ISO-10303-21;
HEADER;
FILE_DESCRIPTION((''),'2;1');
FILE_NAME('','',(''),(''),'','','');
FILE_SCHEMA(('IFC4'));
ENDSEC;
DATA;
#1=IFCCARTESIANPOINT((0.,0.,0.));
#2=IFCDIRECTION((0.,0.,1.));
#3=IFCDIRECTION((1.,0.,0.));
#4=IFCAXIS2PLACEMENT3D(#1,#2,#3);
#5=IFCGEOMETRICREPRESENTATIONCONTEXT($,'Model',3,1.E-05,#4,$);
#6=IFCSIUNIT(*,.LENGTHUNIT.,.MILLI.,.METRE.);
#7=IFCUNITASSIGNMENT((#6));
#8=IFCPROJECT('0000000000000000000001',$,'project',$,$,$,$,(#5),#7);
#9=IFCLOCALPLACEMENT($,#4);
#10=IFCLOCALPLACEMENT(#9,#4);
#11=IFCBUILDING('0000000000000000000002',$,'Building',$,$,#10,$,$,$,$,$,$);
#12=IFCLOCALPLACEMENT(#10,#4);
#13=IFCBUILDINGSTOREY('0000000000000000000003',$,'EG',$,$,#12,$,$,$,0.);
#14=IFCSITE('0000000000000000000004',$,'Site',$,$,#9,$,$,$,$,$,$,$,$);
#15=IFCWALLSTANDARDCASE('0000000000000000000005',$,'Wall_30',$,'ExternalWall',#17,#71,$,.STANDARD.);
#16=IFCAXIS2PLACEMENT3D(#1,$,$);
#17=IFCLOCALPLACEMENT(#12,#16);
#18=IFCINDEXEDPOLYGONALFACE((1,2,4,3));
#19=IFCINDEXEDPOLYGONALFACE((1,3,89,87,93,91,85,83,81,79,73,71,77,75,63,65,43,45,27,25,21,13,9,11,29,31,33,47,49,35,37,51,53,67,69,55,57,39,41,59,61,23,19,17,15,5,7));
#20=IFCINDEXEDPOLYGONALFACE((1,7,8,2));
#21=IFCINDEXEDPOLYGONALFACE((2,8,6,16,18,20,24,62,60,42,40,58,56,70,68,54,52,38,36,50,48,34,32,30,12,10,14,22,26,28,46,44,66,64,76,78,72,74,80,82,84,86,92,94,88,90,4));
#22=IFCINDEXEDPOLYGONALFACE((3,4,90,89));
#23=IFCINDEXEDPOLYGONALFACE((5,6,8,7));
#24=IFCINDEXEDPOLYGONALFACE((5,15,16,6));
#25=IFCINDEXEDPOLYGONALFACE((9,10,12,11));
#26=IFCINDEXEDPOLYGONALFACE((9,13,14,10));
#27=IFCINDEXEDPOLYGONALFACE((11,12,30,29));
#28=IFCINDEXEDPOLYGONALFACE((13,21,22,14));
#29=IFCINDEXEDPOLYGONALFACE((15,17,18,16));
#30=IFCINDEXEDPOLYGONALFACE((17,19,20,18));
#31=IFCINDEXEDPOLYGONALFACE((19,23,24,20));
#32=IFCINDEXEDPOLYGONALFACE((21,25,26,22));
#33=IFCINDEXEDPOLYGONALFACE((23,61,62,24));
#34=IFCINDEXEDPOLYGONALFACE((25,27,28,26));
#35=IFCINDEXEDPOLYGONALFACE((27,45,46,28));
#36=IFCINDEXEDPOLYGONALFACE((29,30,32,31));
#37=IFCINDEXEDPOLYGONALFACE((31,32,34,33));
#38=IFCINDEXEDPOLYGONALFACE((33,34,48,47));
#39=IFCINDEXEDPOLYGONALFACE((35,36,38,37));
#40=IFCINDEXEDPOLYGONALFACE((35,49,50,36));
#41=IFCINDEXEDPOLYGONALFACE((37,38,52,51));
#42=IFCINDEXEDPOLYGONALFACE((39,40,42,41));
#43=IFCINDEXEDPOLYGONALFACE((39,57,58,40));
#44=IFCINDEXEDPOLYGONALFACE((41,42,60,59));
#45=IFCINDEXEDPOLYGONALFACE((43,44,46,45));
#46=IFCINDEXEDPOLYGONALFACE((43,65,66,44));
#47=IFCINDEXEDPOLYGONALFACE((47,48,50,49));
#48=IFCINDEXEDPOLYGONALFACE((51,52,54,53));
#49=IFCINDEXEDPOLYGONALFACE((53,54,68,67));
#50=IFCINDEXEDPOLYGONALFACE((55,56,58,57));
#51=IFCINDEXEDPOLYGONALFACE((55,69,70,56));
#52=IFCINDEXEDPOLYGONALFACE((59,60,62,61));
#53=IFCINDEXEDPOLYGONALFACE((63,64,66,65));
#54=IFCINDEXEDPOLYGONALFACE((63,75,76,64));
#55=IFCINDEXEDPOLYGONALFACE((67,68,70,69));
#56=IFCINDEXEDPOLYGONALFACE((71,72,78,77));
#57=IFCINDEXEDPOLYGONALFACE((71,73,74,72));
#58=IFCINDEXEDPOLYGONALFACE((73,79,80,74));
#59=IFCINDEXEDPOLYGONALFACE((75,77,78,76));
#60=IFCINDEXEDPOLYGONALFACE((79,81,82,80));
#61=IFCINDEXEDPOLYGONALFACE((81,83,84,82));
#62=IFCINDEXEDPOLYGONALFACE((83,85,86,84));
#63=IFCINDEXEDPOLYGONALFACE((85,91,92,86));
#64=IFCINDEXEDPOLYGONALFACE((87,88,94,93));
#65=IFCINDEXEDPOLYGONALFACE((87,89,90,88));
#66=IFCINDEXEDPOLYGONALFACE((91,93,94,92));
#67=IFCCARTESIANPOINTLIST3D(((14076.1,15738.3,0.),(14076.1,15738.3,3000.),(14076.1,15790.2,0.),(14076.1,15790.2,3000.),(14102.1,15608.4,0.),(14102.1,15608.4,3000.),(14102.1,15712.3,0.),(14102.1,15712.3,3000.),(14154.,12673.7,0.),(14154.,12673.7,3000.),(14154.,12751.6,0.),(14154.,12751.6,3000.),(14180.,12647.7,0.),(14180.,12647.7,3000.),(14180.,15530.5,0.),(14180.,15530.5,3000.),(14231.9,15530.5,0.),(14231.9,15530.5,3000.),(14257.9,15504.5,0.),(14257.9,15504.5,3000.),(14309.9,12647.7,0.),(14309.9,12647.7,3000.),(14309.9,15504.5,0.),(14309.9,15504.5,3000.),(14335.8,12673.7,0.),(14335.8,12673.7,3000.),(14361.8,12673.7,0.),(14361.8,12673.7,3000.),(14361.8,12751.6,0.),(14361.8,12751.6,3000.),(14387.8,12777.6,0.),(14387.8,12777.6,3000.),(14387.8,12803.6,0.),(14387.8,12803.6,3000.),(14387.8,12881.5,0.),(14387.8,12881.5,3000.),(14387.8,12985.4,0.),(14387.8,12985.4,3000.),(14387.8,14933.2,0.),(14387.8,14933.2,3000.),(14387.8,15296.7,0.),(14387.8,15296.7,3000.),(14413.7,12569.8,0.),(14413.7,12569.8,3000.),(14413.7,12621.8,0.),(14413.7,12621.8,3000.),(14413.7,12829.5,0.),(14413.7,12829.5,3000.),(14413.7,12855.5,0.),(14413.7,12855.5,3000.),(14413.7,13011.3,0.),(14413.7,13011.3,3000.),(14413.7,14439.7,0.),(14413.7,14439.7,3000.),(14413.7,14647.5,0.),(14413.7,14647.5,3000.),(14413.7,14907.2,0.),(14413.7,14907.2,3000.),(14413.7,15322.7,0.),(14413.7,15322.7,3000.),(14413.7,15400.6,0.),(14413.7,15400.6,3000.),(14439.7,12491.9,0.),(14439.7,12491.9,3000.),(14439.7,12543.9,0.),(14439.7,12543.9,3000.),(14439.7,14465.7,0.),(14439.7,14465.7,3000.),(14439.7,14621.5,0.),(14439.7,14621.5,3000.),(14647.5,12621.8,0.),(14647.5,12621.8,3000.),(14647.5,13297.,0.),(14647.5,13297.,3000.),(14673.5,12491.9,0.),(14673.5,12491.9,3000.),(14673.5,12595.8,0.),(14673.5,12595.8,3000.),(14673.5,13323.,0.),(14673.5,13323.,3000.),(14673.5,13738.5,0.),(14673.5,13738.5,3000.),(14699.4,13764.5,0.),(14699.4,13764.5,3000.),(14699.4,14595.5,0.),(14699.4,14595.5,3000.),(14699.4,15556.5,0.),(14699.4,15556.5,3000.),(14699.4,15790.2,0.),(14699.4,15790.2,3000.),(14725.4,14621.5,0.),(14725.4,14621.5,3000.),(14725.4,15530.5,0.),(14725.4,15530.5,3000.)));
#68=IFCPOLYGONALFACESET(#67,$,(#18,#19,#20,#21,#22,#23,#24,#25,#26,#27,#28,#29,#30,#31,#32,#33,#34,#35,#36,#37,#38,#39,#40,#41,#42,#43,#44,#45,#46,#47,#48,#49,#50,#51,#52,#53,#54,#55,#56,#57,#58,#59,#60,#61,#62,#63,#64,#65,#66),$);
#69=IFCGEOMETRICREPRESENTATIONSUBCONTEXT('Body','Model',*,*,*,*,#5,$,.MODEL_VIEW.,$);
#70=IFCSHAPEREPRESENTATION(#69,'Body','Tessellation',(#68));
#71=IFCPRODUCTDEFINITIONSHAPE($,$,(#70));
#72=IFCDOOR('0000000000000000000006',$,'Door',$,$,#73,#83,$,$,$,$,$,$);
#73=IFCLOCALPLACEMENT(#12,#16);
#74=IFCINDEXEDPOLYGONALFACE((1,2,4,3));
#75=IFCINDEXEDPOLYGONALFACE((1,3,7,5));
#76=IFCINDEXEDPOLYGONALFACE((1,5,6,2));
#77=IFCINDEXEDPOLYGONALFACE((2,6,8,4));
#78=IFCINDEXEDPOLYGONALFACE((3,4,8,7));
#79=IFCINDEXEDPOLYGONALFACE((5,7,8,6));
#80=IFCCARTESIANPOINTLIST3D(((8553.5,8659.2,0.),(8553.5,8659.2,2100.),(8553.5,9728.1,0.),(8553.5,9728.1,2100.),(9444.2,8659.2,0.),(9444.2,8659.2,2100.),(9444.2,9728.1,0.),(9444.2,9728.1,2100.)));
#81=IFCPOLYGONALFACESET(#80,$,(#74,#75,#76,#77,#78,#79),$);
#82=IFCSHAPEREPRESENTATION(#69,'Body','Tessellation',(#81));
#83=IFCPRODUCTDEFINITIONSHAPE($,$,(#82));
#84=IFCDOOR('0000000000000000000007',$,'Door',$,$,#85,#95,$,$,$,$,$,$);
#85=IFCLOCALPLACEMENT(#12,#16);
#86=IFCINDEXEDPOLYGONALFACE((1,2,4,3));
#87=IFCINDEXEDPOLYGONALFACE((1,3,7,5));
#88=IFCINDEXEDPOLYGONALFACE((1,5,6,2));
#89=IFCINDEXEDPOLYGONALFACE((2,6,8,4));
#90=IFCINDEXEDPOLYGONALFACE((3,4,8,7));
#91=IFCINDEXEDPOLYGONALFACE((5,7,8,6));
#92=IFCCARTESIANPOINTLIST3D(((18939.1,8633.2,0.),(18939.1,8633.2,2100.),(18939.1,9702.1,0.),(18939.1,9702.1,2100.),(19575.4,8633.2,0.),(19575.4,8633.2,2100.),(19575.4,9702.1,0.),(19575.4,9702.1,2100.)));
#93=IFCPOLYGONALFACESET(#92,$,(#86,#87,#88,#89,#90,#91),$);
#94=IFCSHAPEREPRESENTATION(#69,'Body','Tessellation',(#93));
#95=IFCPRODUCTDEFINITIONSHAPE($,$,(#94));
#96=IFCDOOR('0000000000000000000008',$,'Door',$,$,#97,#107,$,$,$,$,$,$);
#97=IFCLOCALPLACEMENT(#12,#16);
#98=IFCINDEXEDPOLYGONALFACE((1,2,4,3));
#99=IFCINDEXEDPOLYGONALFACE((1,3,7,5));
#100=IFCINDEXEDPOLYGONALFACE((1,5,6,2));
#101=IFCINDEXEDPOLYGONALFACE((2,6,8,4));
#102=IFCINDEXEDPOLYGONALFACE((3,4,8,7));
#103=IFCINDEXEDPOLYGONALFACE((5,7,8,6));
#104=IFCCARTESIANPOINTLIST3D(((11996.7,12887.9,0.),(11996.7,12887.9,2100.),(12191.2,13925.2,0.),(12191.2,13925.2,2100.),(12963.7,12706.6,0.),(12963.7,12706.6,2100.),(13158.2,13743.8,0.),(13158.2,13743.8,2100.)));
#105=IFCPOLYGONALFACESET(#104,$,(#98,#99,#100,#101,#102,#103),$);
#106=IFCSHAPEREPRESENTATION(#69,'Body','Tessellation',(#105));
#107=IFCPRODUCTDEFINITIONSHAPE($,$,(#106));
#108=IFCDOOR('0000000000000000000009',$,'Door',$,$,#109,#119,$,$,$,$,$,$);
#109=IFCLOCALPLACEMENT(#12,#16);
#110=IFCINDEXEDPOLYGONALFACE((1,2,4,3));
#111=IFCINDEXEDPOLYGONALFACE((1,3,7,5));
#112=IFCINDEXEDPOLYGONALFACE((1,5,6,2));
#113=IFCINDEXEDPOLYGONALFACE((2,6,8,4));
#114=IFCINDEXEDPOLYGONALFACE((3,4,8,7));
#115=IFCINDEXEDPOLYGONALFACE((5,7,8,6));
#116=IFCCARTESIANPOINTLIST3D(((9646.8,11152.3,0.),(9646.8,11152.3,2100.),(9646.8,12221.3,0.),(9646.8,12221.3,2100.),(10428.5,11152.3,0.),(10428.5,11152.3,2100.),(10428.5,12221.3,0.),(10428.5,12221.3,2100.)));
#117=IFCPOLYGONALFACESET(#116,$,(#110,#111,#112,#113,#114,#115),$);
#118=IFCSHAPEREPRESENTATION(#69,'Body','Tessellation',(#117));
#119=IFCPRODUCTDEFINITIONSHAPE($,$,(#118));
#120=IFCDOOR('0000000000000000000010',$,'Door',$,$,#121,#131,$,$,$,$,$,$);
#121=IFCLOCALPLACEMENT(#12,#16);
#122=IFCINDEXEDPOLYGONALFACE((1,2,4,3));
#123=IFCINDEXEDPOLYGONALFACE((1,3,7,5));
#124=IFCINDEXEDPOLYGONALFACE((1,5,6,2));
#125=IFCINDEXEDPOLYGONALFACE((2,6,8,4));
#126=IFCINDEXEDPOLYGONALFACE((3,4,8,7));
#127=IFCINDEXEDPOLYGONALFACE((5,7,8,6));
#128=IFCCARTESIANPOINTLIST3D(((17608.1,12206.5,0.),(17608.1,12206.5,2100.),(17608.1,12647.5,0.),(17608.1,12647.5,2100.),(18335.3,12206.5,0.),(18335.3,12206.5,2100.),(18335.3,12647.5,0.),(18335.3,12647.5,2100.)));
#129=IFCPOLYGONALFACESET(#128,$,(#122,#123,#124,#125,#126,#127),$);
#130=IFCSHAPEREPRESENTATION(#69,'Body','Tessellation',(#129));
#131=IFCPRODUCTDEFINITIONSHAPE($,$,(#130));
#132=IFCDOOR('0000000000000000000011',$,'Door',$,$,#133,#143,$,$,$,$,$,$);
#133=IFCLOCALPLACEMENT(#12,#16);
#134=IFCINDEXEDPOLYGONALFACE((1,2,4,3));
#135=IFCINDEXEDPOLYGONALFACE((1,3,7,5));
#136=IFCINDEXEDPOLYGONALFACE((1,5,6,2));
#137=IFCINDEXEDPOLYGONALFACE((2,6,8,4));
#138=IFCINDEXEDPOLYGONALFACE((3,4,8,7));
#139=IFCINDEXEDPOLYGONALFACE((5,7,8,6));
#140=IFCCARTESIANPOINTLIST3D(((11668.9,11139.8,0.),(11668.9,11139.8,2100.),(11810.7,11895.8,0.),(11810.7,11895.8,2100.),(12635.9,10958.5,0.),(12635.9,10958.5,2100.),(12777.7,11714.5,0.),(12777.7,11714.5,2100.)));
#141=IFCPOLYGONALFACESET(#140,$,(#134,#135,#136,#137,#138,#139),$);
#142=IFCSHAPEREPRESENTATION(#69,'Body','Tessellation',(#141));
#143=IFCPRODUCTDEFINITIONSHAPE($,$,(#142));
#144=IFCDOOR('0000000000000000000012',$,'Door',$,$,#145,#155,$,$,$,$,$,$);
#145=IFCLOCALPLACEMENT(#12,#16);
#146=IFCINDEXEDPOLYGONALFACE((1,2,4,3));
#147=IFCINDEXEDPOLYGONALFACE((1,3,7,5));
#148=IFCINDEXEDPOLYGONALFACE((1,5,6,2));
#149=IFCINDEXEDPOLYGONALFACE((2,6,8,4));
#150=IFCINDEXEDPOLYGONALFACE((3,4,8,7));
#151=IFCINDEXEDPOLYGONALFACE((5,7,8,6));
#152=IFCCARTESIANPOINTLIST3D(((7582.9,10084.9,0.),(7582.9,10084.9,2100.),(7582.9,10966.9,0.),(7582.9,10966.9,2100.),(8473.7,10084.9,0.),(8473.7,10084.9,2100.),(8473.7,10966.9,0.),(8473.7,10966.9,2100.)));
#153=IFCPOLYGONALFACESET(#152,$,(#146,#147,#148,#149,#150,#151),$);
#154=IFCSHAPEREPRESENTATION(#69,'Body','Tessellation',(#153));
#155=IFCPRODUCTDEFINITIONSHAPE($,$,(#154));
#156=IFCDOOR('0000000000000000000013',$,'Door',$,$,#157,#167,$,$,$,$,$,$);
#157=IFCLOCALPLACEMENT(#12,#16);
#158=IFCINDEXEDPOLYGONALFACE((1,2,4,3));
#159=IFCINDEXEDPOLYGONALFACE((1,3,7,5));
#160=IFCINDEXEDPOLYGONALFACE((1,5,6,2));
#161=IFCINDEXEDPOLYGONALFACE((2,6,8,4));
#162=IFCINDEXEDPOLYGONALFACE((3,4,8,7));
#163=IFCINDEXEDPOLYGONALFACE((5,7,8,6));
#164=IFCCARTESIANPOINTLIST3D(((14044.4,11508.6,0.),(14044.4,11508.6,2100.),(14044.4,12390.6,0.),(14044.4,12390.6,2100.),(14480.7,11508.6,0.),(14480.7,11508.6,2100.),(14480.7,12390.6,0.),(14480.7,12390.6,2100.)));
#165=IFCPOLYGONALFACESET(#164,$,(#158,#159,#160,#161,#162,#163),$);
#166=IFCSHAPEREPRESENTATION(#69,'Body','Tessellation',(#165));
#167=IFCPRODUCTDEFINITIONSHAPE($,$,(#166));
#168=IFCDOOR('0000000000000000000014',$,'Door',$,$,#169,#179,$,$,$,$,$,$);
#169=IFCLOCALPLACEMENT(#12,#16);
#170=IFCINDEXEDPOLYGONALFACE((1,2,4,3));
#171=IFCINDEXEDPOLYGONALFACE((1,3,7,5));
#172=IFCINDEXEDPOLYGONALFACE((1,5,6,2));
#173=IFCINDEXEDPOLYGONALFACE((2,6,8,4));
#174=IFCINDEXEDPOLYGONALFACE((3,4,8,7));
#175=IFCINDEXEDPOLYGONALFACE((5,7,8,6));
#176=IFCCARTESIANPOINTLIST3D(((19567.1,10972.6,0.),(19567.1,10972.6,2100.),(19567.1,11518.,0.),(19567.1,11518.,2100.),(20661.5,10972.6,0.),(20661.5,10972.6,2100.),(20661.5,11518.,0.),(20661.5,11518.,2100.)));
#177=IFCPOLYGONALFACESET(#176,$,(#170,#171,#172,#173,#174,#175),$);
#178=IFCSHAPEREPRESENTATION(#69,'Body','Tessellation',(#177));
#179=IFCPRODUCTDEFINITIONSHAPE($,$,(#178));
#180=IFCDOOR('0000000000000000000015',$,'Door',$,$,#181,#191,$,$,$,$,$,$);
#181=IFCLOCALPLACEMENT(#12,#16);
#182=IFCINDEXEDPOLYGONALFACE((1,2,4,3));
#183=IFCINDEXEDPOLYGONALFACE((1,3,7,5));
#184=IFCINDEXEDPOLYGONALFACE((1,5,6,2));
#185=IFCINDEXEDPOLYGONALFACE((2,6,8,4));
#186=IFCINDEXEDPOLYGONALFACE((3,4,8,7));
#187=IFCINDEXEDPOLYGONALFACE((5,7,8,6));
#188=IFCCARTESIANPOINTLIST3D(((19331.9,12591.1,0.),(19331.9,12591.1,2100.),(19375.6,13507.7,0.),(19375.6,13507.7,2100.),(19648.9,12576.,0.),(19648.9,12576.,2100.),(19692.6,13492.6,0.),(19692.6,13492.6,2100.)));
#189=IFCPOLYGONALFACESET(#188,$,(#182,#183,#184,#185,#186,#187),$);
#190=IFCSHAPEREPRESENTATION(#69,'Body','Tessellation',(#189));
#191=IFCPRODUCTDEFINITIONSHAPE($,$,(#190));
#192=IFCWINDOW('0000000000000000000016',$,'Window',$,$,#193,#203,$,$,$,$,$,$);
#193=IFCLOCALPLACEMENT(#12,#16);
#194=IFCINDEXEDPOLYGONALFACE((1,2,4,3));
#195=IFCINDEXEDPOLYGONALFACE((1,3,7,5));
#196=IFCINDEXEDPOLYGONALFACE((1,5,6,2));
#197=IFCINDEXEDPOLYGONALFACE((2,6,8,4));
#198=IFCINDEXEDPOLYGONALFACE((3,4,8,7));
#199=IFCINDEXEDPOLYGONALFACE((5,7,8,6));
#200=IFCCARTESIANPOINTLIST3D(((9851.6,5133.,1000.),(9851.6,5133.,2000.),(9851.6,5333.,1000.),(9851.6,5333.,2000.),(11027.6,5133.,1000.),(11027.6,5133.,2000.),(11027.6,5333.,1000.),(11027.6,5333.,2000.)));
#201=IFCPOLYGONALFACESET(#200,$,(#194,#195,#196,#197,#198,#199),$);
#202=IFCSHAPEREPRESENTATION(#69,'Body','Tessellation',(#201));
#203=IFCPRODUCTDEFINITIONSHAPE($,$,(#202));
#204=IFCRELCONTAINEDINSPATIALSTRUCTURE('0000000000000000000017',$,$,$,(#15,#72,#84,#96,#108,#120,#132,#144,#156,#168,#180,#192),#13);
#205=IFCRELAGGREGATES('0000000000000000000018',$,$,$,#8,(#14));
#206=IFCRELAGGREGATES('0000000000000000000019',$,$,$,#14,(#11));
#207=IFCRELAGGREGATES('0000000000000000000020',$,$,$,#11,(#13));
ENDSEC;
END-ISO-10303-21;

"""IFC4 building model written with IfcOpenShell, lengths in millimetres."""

from ifc_helpers import new_model, si_unit, frame, origin_with_axes, place, context, subcontext, project, spatial, polyline, rectangle, outline, extrude, element, save


model = new_model("IFC4")

# Units and contexts
model_context = context("Model", 3, precision=1e-05, world=origin_with_axes())
body_context = subcontext(model_context, "Body", "Model", "MODEL_VIEW")
ifc_project = project(units=[si_unit("LENGTHUNIT", "METRE", prefix="MILLI")], contexts=[model_context])

# Site, building, storey
site_placement = place(None, origin_with_axes())
site = spatial("IfcSite", under=ifc_project, at=site_placement, Name="Site")
building_placement = place(site_placement, origin_with_axes())
building = spatial("IfcBuilding", under=site, at=building_placement, Name="Building")
storey_placement = place(building_placement, origin_with_axes())
storey = spatial("IfcBuildingStorey", under=building, at=storey_placement, Name="EG", Elevation=0.0)

# Wall
wall_placement = place(storey_placement, origin_with_axes())
element("IfcWallStandardCase", 1, at=wall_placement, inside=storey, Name="Wall_30", ObjectType="ExternalWall", PredefinedType="STANDARD", context=body_context, shape_type="SweptSolid", body=[
    extrude(outline(polyline([(14439.7, 12491.9, 0.0), (14439.7, 12543.9, 0.0), (14413.7, 12569.8, 0.0), (14413.7, 12621.8, 0.0), (14361.8, 12673.7, 0.0), (14335.8, 12673.7, 0.0), (14309.9, 12647.7, 0.0), (14180.0, 12647.7, 0.0), (14154.0, 12673.7, 0.0), (14154.0, 12751.6, 0.0), (14361.8, 12751.6, 0.0), (14387.8, 12777.6, 0.0), (14387.8, 12803.6, 0.0), (14413.7, 12829.5, 0.0), (14413.7, 12855.5, 0.0), (14387.8, 12881.5, 0.0), (14387.8, 12985.4, 0.0), (14413.7, 13011.3, 0.0), (14413.7, 14439.7, 0.0), (14439.7, 14465.7, 0.0), (14439.7, 14621.5, 0.0), (14413.7, 14647.5, 0.0), (14413.7, 14907.2, 0.0), (14387.8, 14933.2, 0.0), (14387.8, 15296.7, 0.0), (14413.7, 15322.7, 0.0), (14413.7, 15400.6, 0.0), (14309.9, 15504.5, 0.0), (14257.9, 15504.5, 0.0), (14231.9, 15530.5, 0.0), (14180.0, 15530.5, 0.0), (14102.1, 15608.4, 0.0), (14102.1, 15712.3, 0.0), (14076.1, 15738.3, 0.0), (14076.1, 15790.2, 0.0), (14699.4, 15790.2, 0.0), (14699.4, 15556.5, 0.0), (14725.4, 15530.5, 0.0), (14725.4, 14621.5, 0.0), (14699.4, 14595.5, 0.0), (14699.4, 13764.5, 0.0), (14673.5, 13738.5, 0.0), (14673.5, 13323.0, 0.0), (14647.5, 13297.0, 0.0), (14647.5, 12621.8, 0.0), (14673.5, 12595.8, 0.0), (14673.5, 12491.9, 0.0), (14439.7, 12491.9, 0.0)])), origin_with_axes(), (0.0, 0.0, 1.0), 3000.0),
])

# Doors
door_1_placement = place(storey_placement, origin_with_axes())
element("IfcDoor", 2, at=door_1_placement, inside=storey, Name="Door", context=body_context, shape_type="SweptSolid", body=[
    extrude(rectangle(XDim=1069.0, YDim=890.8), frame((8998.9, 9193.6, 0.0), z_axis=(0.0, 0.0, 1.0), x_axis=(0.0, 1.0, 0.0)), (0.0, 0.0, 1.0), 2100.0),
])
door_2_placement = place(storey_placement, origin_with_axes())
element("IfcDoor", 3, at=door_2_placement, inside=storey, Name="Door", context=body_context, shape_type="SweptSolid", body=[
    extrude(rectangle(XDim=1069.0, YDim=636.3), frame((19257.3, 9167.7, 0.0), z_axis=(0.0, 0.0, 1.0), x_axis=(0.0, -1.0, 0.0)), (0.0, 0.0, 1.0), 2100.0),
])
door_3_placement = place(storey_placement, origin_with_axes())
element("IfcDoor", 4, at=door_3_placement, inside=storey, Name="Door", context=body_context, shape_type="SweptSolid", body=[
    extrude(rectangle(XDim=1055.3, YDim=983.9), frame((12577.4, 13315.9, 0.0), z_axis=(0.0, 0.0, 1.0), x_axis=(0.184288, 0.982872, 0.0)), (0.0, 0.0, 1.0), 2100.0),
])
door_4_placement = place(storey_placement, origin_with_axes())
element("IfcDoor", 5, at=door_4_placement, inside=storey, Name="Door", context=body_context, shape_type="SweptSolid", body=[
    extrude(rectangle(XDim=1069.0, YDim=781.7), frame((10037.7, 11686.8, 0.0), z_axis=(0.0, 0.0, 1.0), x_axis=(0.0, -1.0, 0.0)), (0.0, 0.0, 1.0), 2100.0),
])
door_5_placement = place(storey_placement, origin_with_axes())
element("IfcDoor", 6, at=door_5_placement, inside=storey, Name="Door", context=body_context, shape_type="SweptSolid", body=[
    extrude(rectangle(XDim=441.0, YDim=727.2), frame((17971.7, 12427.0, 0.0), z_axis=(0.0, 0.0, 1.0), x_axis=(0.0, 1.0, 0.0)), (0.0, 0.0, 1.0), 2100.0),
])
door_6_placement = place(storey_placement, origin_with_axes())
element("IfcDoor", 7, at=door_6_placement, inside=storey, Name="Door", context=body_context, shape_type="SweptSolid", body=[
    extrude(rectangle(XDim=769.2, YDim=983.9), frame((12223.3, 11427.2, 0.0), z_axis=(0.0, 0.0, 1.0), x_axis=(0.184288, 0.982872, 0.0)), (0.0, 0.0, 1.0), 2100.0),
])
door_7_placement = place(storey_placement, origin_with_axes())
element("IfcDoor", 8, at=door_7_placement, inside=storey, Name="Door", context=body_context, shape_type="SweptSolid", body=[
    extrude(rectangle(XDim=882.0, YDim=890.8), frame((8028.3, 10525.9, 0.0), z_axis=(0.0, 0.0, 1.0), x_axis=(0.0, 1.0, 0.0)), (0.0, 0.0, 1.0), 2100.0),
])
door_8_placement = place(storey_placement, origin_with_axes())
element("IfcDoor", 9, at=door_8_placement, inside=storey, Name="Door", context=body_context, shape_type="SweptSolid", body=[
    extrude(rectangle(XDim=882.0, YDim=436.3), frame((14262.5, 11949.6, 0.0), z_axis=(0.0, 0.0, 1.0), x_axis=(0.0, -1.0, 0.0)), (0.0, 0.0, 1.0), 2100.0),
])
door_9_placement = place(storey_placement, origin_with_axes())
element("IfcDoor", 10, at=door_9_placement, inside=storey, Name="Door", context=body_context, shape_type="SweptSolid", body=[
    extrude(rectangle(XDim=1094.4, YDim=545.4), frame((20114.3, 11245.3, 0.0), z_axis=(0.0, 0.0, 1.0), x_axis=(1.0, 0.0, 0.0)), (0.0, 0.0, 1.0), 2100.0),
])
door_10_placement = place(storey_placement, origin_with_axes())
element("IfcDoor", 11, at=door_10_placement, inside=storey, Name="Door", context=body_context, shape_type="SweptSolid", body=[
    extrude(rectangle(XDim=917.6, YDim=317.3), frame((19512.3, 13041.9, 0.0), z_axis=(0.0, 0.0, 1.0), x_axis=(-0.047565, -0.998868, 0.0)), (0.0, 0.0, 1.0), 2100.0),
])

# Window
window_1_placement = place(storey_placement, origin_with_axes())
element("IfcWindow", 12, at=window_1_placement, inside=storey, Name="Window", context=body_context, shape_type="SweptSolid", body=[
    extrude(rectangle(XDim=1176.0, YDim=200.0), frame((10439.6, 5233.0, 1000.0), z_axis=(0.0, 0.0, 1.0), x_axis=(1.0, 0.0, 0.0)), (0.0, 0.0, 1.0), 1000.0),
])

save(model, "model.ifc")
